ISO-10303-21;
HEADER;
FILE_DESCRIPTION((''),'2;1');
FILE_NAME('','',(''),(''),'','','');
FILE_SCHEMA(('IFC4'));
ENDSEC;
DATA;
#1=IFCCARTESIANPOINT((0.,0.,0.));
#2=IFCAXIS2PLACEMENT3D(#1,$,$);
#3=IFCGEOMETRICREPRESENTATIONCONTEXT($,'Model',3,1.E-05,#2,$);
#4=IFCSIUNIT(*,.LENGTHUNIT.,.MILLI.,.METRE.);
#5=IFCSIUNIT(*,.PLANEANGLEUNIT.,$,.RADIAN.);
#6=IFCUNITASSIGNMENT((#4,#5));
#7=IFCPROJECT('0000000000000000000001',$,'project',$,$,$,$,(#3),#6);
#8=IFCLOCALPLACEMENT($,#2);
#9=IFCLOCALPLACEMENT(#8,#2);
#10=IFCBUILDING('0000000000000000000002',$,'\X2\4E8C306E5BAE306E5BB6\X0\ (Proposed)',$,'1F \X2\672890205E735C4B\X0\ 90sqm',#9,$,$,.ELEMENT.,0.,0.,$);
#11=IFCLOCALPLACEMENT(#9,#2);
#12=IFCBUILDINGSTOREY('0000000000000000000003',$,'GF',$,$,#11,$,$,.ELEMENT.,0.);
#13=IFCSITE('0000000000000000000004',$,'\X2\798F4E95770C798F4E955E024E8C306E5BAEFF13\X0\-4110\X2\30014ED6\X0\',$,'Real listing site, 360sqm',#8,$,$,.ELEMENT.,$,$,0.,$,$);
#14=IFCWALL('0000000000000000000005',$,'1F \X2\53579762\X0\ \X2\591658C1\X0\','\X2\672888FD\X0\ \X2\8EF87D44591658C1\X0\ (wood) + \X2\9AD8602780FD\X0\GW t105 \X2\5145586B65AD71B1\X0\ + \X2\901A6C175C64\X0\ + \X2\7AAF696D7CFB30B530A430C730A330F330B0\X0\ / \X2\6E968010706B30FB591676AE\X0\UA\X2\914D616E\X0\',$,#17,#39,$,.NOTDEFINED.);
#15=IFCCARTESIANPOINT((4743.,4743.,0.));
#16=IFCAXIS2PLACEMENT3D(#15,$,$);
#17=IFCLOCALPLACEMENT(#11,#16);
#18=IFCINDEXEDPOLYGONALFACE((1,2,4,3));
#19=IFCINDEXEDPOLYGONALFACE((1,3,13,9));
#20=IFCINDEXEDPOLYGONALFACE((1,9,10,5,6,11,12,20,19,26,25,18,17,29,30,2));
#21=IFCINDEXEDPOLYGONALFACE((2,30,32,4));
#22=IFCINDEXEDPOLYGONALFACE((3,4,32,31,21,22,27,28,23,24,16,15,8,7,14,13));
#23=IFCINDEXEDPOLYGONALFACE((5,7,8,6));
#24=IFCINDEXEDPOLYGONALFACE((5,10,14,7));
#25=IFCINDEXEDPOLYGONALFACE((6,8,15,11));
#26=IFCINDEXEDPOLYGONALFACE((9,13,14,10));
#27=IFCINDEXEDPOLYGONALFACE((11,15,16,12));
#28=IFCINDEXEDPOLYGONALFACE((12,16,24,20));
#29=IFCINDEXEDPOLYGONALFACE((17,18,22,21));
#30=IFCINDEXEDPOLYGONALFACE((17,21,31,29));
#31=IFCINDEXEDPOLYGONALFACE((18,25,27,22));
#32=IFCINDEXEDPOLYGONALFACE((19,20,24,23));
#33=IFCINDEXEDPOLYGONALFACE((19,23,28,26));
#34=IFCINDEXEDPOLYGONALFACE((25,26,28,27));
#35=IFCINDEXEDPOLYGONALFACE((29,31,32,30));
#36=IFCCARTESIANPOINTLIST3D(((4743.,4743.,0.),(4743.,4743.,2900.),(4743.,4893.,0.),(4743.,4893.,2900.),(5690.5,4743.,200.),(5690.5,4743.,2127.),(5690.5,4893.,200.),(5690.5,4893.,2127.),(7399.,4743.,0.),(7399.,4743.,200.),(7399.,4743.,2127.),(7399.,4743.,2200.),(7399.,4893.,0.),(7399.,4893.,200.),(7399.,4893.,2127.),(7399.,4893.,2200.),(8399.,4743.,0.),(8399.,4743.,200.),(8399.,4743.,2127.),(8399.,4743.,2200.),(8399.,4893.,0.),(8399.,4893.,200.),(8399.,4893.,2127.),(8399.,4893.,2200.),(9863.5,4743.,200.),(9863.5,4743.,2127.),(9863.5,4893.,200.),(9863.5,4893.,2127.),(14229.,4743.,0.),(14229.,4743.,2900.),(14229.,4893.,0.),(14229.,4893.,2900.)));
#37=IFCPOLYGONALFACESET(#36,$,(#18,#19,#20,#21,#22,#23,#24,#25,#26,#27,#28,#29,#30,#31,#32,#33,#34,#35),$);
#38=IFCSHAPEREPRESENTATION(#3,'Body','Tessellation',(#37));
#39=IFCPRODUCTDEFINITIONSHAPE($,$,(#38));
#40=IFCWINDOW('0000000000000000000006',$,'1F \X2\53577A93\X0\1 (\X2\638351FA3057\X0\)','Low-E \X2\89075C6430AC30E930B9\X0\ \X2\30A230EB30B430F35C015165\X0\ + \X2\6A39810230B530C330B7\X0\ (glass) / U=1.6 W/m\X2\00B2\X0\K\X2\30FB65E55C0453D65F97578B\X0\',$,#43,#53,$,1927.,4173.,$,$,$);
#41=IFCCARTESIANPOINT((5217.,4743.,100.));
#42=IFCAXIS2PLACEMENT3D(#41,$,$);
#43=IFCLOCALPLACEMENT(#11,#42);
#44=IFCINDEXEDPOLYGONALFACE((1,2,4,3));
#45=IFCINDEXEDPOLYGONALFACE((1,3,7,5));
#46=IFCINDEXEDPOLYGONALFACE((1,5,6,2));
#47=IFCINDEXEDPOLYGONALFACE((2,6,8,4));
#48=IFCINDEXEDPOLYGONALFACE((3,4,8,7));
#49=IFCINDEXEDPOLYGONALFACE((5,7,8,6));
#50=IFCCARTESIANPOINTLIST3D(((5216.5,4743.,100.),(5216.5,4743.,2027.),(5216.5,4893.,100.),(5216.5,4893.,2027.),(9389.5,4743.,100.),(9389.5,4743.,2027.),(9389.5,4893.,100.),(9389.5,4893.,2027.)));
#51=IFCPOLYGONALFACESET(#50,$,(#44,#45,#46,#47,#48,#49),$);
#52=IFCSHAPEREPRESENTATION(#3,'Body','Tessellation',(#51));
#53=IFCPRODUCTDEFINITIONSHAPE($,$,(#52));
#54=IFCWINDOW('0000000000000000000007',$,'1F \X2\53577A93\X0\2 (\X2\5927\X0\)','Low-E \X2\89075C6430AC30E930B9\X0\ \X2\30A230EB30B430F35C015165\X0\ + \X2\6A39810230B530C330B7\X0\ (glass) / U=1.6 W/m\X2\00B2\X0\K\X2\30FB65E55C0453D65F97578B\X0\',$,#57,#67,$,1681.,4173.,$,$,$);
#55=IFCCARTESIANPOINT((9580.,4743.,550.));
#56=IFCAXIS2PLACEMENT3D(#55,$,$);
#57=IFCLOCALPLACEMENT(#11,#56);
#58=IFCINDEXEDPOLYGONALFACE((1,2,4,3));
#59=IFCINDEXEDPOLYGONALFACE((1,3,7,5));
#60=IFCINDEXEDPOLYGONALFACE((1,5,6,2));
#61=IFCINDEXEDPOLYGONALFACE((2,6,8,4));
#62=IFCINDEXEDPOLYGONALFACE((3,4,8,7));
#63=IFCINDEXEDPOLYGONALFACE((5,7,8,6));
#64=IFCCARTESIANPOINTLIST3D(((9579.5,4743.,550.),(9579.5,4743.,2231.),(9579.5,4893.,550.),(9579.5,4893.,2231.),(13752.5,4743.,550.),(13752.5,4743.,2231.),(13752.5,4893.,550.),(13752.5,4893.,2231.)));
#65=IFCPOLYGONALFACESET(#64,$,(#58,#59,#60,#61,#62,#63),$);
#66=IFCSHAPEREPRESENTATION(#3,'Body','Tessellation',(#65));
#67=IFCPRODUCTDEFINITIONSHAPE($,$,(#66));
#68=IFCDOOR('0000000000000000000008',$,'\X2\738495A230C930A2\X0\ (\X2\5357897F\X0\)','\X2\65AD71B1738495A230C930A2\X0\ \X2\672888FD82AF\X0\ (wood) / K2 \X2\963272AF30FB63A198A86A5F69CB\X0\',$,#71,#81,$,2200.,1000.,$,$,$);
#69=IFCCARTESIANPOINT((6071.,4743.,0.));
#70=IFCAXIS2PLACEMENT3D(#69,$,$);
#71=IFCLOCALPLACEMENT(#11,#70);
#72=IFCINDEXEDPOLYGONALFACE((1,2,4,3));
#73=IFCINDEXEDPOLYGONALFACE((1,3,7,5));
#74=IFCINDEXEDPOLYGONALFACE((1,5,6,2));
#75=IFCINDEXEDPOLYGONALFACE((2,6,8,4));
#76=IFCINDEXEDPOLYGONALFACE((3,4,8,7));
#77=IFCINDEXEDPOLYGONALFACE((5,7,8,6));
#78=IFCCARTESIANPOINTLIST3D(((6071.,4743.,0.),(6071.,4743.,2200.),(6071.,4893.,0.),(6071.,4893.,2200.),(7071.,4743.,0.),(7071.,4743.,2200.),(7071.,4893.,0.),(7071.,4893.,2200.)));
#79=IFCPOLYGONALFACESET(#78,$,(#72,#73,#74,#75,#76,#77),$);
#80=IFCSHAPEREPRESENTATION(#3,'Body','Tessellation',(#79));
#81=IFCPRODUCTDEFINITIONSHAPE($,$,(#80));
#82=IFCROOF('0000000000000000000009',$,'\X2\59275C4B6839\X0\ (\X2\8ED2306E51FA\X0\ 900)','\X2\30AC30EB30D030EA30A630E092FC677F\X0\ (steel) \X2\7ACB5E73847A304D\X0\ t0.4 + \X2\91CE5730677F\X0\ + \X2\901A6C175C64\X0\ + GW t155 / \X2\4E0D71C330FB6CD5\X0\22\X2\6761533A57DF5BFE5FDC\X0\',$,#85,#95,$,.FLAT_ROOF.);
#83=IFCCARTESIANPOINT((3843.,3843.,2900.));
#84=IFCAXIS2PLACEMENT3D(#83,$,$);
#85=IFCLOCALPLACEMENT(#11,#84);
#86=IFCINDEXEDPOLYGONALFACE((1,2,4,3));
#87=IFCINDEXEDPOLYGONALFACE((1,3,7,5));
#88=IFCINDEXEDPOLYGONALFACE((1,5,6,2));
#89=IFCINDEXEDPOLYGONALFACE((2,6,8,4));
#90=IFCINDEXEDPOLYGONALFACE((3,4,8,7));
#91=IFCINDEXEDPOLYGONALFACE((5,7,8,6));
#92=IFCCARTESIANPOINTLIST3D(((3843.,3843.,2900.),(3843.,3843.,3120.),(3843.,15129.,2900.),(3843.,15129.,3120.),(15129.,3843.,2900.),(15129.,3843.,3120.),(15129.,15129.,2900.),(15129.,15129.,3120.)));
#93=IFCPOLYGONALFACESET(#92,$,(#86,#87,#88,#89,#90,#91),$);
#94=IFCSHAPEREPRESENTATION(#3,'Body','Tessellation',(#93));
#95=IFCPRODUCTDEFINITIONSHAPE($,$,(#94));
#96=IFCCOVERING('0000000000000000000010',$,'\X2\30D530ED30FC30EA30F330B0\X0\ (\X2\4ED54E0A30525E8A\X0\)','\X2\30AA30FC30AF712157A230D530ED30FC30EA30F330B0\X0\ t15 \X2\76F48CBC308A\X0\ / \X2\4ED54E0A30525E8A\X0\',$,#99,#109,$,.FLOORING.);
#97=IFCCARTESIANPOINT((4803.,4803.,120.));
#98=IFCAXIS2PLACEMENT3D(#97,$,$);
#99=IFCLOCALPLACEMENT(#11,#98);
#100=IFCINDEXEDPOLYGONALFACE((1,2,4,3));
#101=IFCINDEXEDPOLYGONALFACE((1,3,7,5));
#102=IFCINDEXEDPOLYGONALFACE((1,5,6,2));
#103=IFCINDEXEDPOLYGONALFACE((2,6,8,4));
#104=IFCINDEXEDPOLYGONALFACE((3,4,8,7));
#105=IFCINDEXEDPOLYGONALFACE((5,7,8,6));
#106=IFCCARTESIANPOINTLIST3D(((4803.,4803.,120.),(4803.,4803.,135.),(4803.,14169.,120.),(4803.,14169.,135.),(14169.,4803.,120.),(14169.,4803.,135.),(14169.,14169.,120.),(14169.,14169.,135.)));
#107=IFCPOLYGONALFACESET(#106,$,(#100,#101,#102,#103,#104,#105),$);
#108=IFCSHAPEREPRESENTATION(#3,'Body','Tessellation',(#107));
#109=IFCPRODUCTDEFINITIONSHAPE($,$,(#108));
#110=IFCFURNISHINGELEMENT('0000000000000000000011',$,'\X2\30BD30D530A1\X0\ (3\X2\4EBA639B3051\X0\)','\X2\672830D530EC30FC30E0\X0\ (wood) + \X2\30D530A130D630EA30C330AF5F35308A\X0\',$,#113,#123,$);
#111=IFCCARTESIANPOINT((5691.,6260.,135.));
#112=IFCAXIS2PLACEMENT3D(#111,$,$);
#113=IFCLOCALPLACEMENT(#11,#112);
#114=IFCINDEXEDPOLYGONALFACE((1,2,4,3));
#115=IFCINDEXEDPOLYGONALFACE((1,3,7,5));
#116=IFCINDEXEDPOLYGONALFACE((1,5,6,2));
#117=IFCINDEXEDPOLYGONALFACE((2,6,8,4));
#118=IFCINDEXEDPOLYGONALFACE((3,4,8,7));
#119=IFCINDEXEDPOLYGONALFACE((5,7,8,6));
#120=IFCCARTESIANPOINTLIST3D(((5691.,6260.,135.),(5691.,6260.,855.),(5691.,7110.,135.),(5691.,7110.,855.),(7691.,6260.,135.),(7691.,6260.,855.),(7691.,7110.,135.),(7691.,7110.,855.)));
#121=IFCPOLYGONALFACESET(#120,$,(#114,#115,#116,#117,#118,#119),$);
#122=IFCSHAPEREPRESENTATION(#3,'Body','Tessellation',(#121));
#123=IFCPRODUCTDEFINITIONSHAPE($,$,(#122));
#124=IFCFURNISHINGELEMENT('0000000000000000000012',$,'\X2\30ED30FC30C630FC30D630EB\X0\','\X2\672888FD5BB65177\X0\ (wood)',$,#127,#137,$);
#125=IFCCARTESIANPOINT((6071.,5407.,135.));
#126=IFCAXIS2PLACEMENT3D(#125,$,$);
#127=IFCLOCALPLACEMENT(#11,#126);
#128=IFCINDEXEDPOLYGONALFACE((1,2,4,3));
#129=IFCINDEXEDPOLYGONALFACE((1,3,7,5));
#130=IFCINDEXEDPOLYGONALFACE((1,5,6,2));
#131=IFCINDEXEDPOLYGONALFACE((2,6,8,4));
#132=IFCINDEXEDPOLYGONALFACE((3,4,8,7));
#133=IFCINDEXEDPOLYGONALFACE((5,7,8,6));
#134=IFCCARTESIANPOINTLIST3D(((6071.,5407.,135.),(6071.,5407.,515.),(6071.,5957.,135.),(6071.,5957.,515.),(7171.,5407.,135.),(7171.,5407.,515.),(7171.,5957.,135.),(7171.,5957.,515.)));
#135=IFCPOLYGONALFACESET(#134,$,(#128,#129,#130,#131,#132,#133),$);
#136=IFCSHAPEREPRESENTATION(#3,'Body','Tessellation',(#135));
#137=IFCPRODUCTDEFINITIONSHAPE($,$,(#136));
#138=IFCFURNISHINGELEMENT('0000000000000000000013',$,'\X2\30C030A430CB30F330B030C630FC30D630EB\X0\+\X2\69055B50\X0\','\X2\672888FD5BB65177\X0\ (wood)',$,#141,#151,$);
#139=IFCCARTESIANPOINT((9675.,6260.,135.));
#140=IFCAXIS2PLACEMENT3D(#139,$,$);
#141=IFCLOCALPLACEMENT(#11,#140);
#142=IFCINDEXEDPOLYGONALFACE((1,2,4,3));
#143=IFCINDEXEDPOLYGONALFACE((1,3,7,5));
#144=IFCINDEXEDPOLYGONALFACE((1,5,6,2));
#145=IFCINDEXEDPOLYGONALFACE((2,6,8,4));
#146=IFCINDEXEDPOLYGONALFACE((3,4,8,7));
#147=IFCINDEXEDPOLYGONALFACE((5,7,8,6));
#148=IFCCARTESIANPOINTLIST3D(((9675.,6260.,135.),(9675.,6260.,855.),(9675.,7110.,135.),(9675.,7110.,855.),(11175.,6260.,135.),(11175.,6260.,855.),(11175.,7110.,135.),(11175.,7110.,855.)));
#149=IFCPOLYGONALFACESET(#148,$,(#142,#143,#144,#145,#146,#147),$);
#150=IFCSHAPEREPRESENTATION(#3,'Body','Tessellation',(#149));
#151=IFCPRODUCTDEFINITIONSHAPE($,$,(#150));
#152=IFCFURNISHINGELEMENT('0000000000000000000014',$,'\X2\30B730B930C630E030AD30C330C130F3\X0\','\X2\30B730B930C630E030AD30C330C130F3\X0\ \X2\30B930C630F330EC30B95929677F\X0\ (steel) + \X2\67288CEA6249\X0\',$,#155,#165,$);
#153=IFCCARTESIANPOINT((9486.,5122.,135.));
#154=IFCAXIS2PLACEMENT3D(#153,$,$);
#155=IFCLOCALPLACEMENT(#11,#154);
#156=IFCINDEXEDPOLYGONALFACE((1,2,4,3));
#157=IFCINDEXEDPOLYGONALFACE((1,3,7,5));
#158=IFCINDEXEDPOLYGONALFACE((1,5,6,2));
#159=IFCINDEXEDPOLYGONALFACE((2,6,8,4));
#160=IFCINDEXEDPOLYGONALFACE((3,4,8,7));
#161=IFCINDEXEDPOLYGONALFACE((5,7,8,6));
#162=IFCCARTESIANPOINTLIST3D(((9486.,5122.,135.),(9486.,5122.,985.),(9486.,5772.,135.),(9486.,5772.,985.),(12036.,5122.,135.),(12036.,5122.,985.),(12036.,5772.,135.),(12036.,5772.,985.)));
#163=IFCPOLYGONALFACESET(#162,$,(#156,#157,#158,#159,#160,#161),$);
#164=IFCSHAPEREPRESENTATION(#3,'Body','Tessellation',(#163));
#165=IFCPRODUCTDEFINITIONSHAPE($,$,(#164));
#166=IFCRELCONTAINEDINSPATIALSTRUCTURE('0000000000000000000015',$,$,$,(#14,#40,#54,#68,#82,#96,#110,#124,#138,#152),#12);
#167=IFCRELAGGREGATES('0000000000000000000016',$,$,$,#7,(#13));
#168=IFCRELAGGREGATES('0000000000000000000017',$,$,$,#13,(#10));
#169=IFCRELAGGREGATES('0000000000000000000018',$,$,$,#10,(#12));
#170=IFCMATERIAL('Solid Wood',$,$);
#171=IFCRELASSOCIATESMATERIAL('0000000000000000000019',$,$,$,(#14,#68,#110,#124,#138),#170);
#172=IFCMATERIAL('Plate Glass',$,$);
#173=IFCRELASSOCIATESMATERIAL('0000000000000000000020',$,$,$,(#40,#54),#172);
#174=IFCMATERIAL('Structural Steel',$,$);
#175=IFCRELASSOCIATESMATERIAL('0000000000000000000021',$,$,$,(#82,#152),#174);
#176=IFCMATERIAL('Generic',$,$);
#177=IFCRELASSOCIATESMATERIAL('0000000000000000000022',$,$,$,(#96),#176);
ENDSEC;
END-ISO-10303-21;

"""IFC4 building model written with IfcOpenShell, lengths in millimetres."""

from ifc_helpers import new_model, si_unit, frame, frame_2d, origin, place, context, project, spatial, rectangle, extrude, material, element, fill, save


model = new_model("IFC4")

# Units and contexts
model_context = context("Model", 3, precision=1e-05, world=origin())
ifc_project = project(units=[si_unit("LENGTHUNIT", "METRE", prefix="MILLI"), si_unit("PLANEANGLEUNIT", "RADIAN")], contexts=[model_context])

# Site, building, storey
site_placement = place(None, origin())
site = spatial("IfcSite", under=ifc_project, at=site_placement, Name="福井県福井市二の宮３-4110、他", ObjectType="Real listing site, 360sqm", CompositionType="ELEMENT", RefElevation=0.0)
building_placement = place(site_placement, origin())
building = spatial("IfcBuilding", under=site, at=building_placement, Name="二の宮の家 (Proposed)", ObjectType="1F 木造平屋 90sqm", CompositionType="ELEMENT", ElevationOfRefHeight=0.0, ElevationOfTerrain=0.0)
storey_placement = place(building_placement, origin())
storey = spatial("IfcBuildingStorey", under=building, at=storey_placement, Name="GF", CompositionType="ELEMENT", Elevation=0.0)

# Shared definitions
ifc_material_1 = material(Name="Solid Wood")

# Wall, openings, windows, door
wall_1_placement = place(storey_placement, frame((4743.0, 4743.0, 0.0)))
wall_1 = element("IfcWall", 1, at=wall_1_placement, inside=storey, material=ifc_material_1, Name="1F 南面 外壁", Description="木製 軸組外壁 (wood) + 高性能GW t105 充填断熱 + 通気層 + 窯業系サイディング / 準耐火・外皮UA配慮", PredefinedType="NOTDEFINED", context=model_context, shape_type="SweptSolid", body=[
    extrude(rectangle(XDim=9486.0, YDim=150.0, at=frame_2d((4743.0, 75.0))), frame((4743.0, 4743.0, 0.0)), (0.0, 0.0, 1.0), 2900.0),
])
opening_1_placement = place(storey_placement, frame((5217.0, 4743.0, 100.0)))
opening_1 = element("IfcOpeningElement", 2, at=opening_1_placement, cuts=wall_1, PredefinedType="NOTDEFINED", context=model_context, shape_type="SweptSolid", body=[
    extrude(rectangle(XDim=4173.0, YDim=150.0, at=frame_2d((2086.0, 75.0))), frame((5217.0, 4743.0, 100.0)), (0.0, 0.0, 1.0), 1927.0),
])
opening_2_placement = place(storey_placement, frame((9580.0, 4743.0, 550.0)))
opening_2 = element("IfcOpeningElement", 3, at=opening_2_placement, cuts=wall_1, PredefinedType="NOTDEFINED", context=model_context, shape_type="SweptSolid", body=[
    extrude(rectangle(XDim=4173.0, YDim=150.0, at=frame_2d((2086.0, 75.0))), frame((9580.0, 4743.0, 550.0)), (0.0, 0.0, 1.0), 1681.0),
])
opening_3_placement = place(storey_placement, frame((6071.0, 4743.0, 0.0)))
opening_3 = element("IfcOpeningElement", 4, at=opening_3_placement, cuts=wall_1, PredefinedType="NOTDEFINED", context=model_context, shape_type="SweptSolid", body=[
    extrude(rectangle(XDim=1000.0, YDim=150.0, at=frame_2d((500.0, 75.0))), frame((6071.0, 4743.0, 0.0)), (0.0, 0.0, 1.0), 2200.0),
])
ifc_material_2 = material(Name="Plate Glass")
window_1_placement = place(storey_placement, frame((5217.0, 4743.0, 100.0)))
window_1 = element("IfcWindow", 5, at=window_1_placement, inside=storey, material=ifc_material_2, Name="1F 南窓1 (掃出し)", Description="Low-E 複層ガラス アルゴン封入 + 樹脂サッシ (glass) / U=1.6 W/m²K・日射取得型", OverallHeight=1927.0, OverallWidth=4173.0, context=model_context, shape_type="SweptSolid", body=[
    extrude(rectangle(XDim=4173.0, YDim=150.0, at=frame_2d((2086.0, 75.0))), frame((5217.0, 4743.0, 100.0)), (0.0, 0.0, 1.0), 1927.0),
])
fill(opening_1, window_1)
window_2_placement = place(storey_placement, frame((9580.0, 4743.0, 550.0)))
window_2 = element("IfcWindow", 6, at=window_2_placement, inside=storey, material=ifc_material_2, Name="1F 南窓2 (大)", Description="Low-E 複層ガラス アルゴン封入 + 樹脂サッシ (glass) / U=1.6 W/m²K・日射取得型", OverallHeight=1681.0, OverallWidth=4173.0, context=model_context, shape_type="SweptSolid", body=[
    extrude(rectangle(XDim=4173.0, YDim=150.0, at=frame_2d((2086.0, 75.0))), frame((9580.0, 4743.0, 550.0)), (0.0, 0.0, 1.0), 1681.0),
])
fill(opening_2, window_2)
door_placement = place(storey_placement, frame((6071.0, 4743.0, 0.0)))
door = element("IfcDoor", 7, at=door_placement, inside=storey, material=ifc_material_1, Name="玄関ドア (南西)", Description="断熱玄関ドア 木製芯 (wood) / K2 防犯・採風機構", OverallHeight=2200.0, OverallWidth=1000.0, context=model_context, shape_type="SweptSolid", body=[
    extrude(rectangle(XDim=1000.0, YDim=150.0, at=frame_2d((500.0, 75.0))), frame((6071.0, 4743.0, 0.0)), (0.0, 0.0, 1.0), 2200.0),
])
fill(opening_3, door)

# Roof
ifc_material_3 = material(Name="Structural Steel")
roof_placement = place(storey_placement, frame((3843.0, 3843.0, 2900.0)))
element("IfcRoof", 8, at=roof_placement, inside=storey, material=ifc_material_3, Name="大屋根 (軒の出 900)", Description="ガルバリウム鋼板 (steel) 立平葺き t0.4 + 野地板 + 通気層 + GW t155 / 不燃・法22条区域対応", PredefinedType="FLAT_ROOF", context=model_context, shape_type="SweptSolid", body=[
    extrude(rectangle(XDim=11286.0, YDim=11286.0, at=frame_2d((5643.0, 5643.0))), frame((3843.0, 3843.0, 2900.0)), (0.0, 0.0, 1.0), 220.0),
])

# Covering
ifc_material_4 = material(Name="Generic")
covering_placement = place(storey_placement, frame((4803.0, 4803.0, 120.0)))
element("IfcCovering", 9, at=covering_placement, inside=storey, material=ifc_material_4, Name="フローリング (仕上げ床)", Description="オーク無垢フローリング t15 直貼り / 仕上げ床", PredefinedType="FLOORING", context=model_context, shape_type="SweptSolid", body=[
    extrude(rectangle(XDim=9366.0, YDim=9366.0, at=frame_2d((4683.0, 4683.0))), frame((4803.0, 4803.0, 120.0)), (0.0, 0.0, 1.0), 15.0),
])

# Furnishing elements
furnishing_1_placement = place(storey_placement, frame((5691.0, 6260.0, 135.0)))
element("IfcFurnishingElement", 10, at=furnishing_1_placement, inside=storey, material=ifc_material_1, Name="ソファ (3人掛け)", Description="木フレーム (wood) + ファブリック張り", context=model_context, shape_type="SweptSolid", body=[
    extrude(rectangle(XDim=2000.0, YDim=850.0, at=frame_2d((1000.0, 425.0))), frame((5691.0, 6260.0, 135.0)), (0.0, 0.0, 1.0), 720.0),
])
furnishing_2_placement = place(storey_placement, frame((6071.0, 5407.0, 135.0)))
element("IfcFurnishingElement", 11, at=furnishing_2_placement, inside=storey, material=ifc_material_1, Name="ローテーブル", Description="木製家具 (wood)", context=model_context, shape_type="SweptSolid", body=[
    extrude(rectangle(XDim=1100.0, YDim=550.0, at=frame_2d((550.0, 275.0))), frame((6071.0, 5407.0, 135.0)), (0.0, 0.0, 1.0), 380.0),
])
furnishing_3_placement = place(storey_placement, frame((9675.0, 6260.0, 135.0)))
element("IfcFurnishingElement", 12, at=furnishing_3_placement, inside=storey, material=ifc_material_1, Name="ダイニングテーブル+椅子", Description="木製家具 (wood)", context=model_context, shape_type="SweptSolid", body=[
    extrude(rectangle(XDim=1500.0, YDim=850.0, at=frame_2d((750.0, 425.0))), frame((9675.0, 6260.0, 135.0)), (0.0, 0.0, 1.0), 720.0),
])
furnishing_4_placement = place(storey_placement, frame((9486.0, 5122.0, 135.0)))
element("IfcFurnishingElement", 13, at=furnishing_4_placement, inside=storey, material=ifc_material_3, Name="システムキッチン", Description="システムキッチン ステンレス天板 (steel) + 木質扉", context=model_context, shape_type="SweptSolid", body=[
    extrude(rectangle(XDim=2550.0, YDim=650.0, at=frame_2d((1275.0, 325.0))), frame((9486.0, 5122.0, 135.0)), (0.0, 0.0, 1.0), 850.0),
])

save(model, "model.ifc")
